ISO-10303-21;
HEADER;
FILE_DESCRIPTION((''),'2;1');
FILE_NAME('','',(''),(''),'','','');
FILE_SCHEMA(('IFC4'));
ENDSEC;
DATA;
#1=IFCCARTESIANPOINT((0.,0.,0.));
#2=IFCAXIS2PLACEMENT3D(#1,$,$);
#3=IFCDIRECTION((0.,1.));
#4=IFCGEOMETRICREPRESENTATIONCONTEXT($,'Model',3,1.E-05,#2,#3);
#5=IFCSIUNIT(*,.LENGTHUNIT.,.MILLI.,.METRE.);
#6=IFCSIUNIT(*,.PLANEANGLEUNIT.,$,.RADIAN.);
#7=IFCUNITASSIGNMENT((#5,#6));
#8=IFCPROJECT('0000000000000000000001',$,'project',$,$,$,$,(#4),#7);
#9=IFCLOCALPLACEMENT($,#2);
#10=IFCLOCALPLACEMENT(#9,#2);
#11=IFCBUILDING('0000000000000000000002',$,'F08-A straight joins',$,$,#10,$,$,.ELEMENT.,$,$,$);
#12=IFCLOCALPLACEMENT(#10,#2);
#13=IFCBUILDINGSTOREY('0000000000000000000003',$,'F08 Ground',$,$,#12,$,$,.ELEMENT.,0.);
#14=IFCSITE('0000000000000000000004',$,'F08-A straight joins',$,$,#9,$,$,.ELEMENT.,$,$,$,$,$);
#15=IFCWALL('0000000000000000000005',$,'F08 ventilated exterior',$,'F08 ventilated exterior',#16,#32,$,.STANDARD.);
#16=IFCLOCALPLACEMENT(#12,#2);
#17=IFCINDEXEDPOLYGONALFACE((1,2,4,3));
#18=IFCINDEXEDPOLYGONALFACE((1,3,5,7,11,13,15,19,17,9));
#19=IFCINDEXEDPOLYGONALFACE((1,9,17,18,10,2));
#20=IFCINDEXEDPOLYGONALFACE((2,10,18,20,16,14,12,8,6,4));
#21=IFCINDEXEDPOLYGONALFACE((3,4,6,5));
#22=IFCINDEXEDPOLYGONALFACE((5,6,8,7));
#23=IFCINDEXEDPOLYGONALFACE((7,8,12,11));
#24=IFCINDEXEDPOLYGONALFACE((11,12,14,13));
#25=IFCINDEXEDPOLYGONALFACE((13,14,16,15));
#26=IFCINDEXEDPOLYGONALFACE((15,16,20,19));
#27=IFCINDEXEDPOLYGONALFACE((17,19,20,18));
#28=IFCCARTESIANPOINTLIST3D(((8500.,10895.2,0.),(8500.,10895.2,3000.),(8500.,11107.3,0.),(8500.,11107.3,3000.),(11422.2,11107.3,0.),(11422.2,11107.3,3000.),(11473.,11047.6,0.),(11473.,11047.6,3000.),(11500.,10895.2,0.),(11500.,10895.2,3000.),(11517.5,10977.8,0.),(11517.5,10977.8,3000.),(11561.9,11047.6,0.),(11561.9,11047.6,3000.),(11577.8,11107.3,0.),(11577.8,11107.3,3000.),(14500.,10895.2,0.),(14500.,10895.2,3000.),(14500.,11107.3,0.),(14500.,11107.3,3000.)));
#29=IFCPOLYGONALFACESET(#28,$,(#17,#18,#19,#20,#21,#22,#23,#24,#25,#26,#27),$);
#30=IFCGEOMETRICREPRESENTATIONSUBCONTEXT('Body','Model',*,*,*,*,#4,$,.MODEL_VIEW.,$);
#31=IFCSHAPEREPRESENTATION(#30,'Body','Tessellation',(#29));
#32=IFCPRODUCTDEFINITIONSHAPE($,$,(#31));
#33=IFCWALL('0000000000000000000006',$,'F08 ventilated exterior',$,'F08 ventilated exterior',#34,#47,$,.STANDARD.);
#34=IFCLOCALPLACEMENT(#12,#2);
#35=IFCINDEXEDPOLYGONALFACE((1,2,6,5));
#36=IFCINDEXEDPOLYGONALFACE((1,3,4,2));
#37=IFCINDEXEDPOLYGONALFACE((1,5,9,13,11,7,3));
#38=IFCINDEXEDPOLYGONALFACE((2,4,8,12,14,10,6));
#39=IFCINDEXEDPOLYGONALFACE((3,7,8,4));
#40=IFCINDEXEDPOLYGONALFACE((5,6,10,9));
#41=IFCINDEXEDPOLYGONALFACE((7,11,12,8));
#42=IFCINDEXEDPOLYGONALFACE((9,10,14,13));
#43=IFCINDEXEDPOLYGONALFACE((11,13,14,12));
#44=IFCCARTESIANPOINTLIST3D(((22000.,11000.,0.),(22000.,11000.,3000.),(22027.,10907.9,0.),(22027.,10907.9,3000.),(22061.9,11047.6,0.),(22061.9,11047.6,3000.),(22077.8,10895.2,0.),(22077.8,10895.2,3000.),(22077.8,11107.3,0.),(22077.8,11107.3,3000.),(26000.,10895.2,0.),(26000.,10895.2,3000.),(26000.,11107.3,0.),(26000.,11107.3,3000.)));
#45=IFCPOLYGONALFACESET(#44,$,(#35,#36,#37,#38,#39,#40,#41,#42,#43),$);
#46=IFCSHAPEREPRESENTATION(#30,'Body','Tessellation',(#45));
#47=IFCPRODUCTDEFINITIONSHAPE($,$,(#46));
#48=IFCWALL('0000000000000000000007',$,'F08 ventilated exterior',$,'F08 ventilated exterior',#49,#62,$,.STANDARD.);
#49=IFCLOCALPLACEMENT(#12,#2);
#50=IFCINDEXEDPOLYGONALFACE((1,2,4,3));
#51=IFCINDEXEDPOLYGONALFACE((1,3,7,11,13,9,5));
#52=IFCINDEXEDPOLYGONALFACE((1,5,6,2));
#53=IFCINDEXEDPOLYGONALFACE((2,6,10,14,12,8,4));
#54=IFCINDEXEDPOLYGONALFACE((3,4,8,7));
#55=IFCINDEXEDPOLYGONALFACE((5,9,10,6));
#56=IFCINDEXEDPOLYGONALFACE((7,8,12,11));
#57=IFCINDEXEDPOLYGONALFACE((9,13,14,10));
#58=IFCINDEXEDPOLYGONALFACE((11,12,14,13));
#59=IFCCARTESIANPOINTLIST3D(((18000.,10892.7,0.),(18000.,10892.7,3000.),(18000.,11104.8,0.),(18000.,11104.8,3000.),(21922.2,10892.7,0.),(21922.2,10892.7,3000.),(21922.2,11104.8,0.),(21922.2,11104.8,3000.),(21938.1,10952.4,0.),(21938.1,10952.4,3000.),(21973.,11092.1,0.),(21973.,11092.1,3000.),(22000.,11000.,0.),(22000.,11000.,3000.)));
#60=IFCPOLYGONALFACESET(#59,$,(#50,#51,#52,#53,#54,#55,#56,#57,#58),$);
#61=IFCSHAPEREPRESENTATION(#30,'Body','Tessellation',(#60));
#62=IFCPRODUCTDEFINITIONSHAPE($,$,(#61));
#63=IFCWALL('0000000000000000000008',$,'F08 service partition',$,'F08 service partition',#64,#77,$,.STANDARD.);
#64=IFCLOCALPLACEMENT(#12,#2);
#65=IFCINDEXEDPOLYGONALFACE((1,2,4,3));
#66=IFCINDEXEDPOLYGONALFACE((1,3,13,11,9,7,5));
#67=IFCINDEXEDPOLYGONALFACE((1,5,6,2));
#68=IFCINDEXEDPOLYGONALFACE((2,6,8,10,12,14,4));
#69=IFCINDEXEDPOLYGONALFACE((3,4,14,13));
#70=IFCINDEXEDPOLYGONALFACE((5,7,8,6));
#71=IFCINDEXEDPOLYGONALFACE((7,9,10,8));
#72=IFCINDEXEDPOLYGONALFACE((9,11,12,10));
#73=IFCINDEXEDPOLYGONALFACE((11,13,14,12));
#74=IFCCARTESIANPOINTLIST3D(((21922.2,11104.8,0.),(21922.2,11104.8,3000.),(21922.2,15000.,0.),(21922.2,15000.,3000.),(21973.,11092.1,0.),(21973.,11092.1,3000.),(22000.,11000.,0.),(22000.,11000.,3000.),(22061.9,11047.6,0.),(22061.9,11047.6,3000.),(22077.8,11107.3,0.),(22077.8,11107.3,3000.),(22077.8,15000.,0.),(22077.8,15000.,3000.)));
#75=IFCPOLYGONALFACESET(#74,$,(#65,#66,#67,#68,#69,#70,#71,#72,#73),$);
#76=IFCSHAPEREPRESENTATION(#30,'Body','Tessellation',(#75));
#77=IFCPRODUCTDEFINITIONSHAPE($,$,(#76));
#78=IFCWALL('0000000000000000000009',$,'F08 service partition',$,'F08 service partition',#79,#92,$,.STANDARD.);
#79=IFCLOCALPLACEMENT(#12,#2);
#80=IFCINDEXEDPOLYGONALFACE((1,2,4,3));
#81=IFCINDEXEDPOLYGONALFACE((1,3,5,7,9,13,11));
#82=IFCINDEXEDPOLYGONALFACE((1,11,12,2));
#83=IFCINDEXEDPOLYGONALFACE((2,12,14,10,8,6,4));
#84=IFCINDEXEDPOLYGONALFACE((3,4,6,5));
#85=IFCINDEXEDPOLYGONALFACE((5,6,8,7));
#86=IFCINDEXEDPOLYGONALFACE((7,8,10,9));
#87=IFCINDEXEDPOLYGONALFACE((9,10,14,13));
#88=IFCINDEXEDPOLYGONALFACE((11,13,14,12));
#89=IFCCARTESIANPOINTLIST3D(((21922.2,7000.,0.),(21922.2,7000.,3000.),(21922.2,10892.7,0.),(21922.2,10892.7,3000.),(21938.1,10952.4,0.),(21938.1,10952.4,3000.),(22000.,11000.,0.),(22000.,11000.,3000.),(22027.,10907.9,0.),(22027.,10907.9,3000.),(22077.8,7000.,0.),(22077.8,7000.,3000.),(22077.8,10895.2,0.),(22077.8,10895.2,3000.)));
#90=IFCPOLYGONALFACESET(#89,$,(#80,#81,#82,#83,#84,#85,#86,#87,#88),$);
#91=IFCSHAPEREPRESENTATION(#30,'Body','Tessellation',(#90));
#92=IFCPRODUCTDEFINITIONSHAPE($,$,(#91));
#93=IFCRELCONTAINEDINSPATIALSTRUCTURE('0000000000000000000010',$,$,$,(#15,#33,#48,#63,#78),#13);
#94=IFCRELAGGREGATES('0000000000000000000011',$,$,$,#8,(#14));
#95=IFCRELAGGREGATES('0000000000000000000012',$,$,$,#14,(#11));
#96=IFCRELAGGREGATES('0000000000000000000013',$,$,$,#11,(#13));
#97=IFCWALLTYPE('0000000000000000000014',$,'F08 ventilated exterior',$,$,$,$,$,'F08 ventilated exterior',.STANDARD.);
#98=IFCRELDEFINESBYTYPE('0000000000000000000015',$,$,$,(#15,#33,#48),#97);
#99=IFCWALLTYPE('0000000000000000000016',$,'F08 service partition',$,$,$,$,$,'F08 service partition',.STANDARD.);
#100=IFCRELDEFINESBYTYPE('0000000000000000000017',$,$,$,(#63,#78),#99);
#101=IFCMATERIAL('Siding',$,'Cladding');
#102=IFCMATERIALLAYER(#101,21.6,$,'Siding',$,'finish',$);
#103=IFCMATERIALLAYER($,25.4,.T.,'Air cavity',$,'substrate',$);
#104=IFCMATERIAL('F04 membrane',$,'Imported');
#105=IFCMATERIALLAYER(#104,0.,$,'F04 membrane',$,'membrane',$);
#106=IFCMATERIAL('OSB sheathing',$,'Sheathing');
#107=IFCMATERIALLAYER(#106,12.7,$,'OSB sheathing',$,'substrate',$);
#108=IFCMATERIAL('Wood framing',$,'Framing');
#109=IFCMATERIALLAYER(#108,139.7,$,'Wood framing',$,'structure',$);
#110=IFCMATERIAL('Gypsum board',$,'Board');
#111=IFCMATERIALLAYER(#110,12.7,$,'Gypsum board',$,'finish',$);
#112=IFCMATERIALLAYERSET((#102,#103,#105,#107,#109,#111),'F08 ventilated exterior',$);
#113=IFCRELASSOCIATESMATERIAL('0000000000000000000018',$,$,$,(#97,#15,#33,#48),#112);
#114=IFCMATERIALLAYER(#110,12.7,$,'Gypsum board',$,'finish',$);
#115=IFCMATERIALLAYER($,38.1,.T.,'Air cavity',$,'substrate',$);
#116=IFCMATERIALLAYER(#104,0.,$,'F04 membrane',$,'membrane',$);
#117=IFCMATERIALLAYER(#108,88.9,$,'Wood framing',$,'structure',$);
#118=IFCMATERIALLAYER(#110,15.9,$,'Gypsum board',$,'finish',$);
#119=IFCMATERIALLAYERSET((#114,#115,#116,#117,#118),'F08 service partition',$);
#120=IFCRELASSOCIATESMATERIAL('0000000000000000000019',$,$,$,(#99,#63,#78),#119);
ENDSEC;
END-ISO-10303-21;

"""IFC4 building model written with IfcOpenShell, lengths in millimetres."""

from ifc_helpers import new_model, si_unit, direction, frame, origin, place, context, subcontext, project, spatial, polyline, outline, extrude, material, layer, layer_set, layer_usage, type_object, element, save


model = new_model("IFC4")

# Units and contexts
model_context = context("Model", 3, precision=1e-05, world=origin(), true_north=direction((0.0, 1.0)))
body_context = subcontext(model_context, "Body", "Model", "MODEL_VIEW")
ifc_project = project(units=[si_unit("LENGTHUNIT", "METRE", prefix="MILLI"), si_unit("PLANEANGLEUNIT", "RADIAN")], contexts=[model_context])

# Site, building, storey
site_placement = place(None, origin())
site = spatial("IfcSite", under=ifc_project, at=site_placement, Name="F08-A straight joins", CompositionType="ELEMENT")
building_placement = place(site_placement, origin())
building = spatial("IfcBuilding", under=site, at=building_placement, Name="F08-A straight joins", CompositionType="ELEMENT")
storey_placement = place(building_placement, origin())
storey = spatial("IfcBuildingStorey", under=building, at=storey_placement, Name="F08 Ground", CompositionType="ELEMENT", Elevation=0.0)

# Walls
ifc_material_1 = material(Name="Siding", Category="Cladding")
ifc_layer_1 = layer(ifc_material_1, 21.6, Name="Siding", Category="finish")
ifc_layer_2 = layer(None, 25.4, ventilated=True, Name="Air cavity", Category="substrate")
ifc_material_2 = material(Name="F04 membrane", Category="Imported")
ifc_layer_3 = layer(ifc_material_2, 0.0, Name="F04 membrane", Category="membrane")
ifc_material_3 = material(Name="OSB sheathing", Category="Sheathing")
ifc_layer_4 = layer(ifc_material_3, 12.7, Name="OSB sheathing", Category="substrate")
ifc_material_4 = material(Name="Wood framing", Category="Framing")
ifc_layer_5 = layer(ifc_material_4, 139.7, Name="Wood framing", Category="structure")
ifc_material_5 = material(Name="Gypsum board", Category="Board")
ifc_layer_6 = layer(ifc_material_5, 12.7, Name="Gypsum board", Category="finish")
ifc_layer_set_1 = layer_set([ifc_layer_1, ifc_layer_2, ifc_layer_3, ifc_layer_4, ifc_layer_5, ifc_layer_6], Name="F08 ventilated exterior")
wall_type_1 = type_object("IfcWallType", Name="F08 ventilated exterior", ElementType="F08 ventilated exterior", PredefinedType="STANDARD", material=ifc_layer_set_1)
ifc_layer_usage_1 = layer_usage(ifc_layer_set_1, "AXIS2", "NEGATIVE", 106.0)
wall_1_placement = place(storey_placement, frame((8500.0, 11001.3, 0.0), z_axis=(0.0, 0.0, 1.0), x_axis=(1.0, 0.0, 0.0)))
element("IfcWall", 1, at=wall_1_placement, inside=storey, type_object=wall_type_1, material=ifc_layer_usage_1, Name="F08 ventilated exterior", ObjectType="F08 ventilated exterior", PredefinedType="STANDARD", context=body_context, shape_type="SweptSolid", body=[
    extrude(outline(polyline([(0.0, -106.0), (3000.0, -106.0), (6000.0, -106.0), (6000.0, 106.0), (3077.8, 106.0), (3061.9, 46.4), (3017.5, -23.5), (2973.0, 46.4), (2922.2, 106.0), (0.0, 106.0), (0.0, -106.0)])), origin(), (0.0, 0.0, 1.0), 3000.0),
])
ifc_layer_usage_2 = layer_usage(ifc_layer_set_1, "AXIS2", "NEGATIVE", 106.0)
wall_2_placement = place(storey_placement, frame((22000.0, 11001.3, 0.0), z_axis=(0.0, 0.0, 1.0), x_axis=(1.0, 0.0, 0.0)))
element("IfcWall", 2, at=wall_2_placement, inside=storey, type_object=wall_type_1, material=ifc_layer_usage_2, Name="F08 ventilated exterior", ObjectType="F08 ventilated exterior", PredefinedType="STANDARD", context=body_context, shape_type="SweptSolid", body=[
    extrude(outline(polyline([(77.8, -106.0), (4000.0, -106.0), (4000.0, 106.0), (77.8, 106.0), (61.9, 46.4), (0.0, -1.3), (27.0, -93.3), (77.8, -106.0)])), origin(), (0.0, 0.0, 1.0), 3000.0),
])
ifc_layer_usage_3 = layer_usage(ifc_layer_set_1, "AXIS2", "NEGATIVE", 106.0)
wall_3_placement = place(storey_placement, frame((22000.0, 10998.7, 0.0), z_axis=(0.0, 0.0, 1.0), x_axis=(-1.0, 0.0, 0.0)))
element("IfcWall", 3, at=wall_3_placement, inside=storey, type_object=wall_type_1, material=ifc_layer_usage_3, Name="F08 ventilated exterior", ObjectType="F08 ventilated exterior", PredefinedType="STANDARD", context=body_context, shape_type="SweptSolid", body=[
    extrude(outline(polyline([(77.8, -106.0), (4000.0, -106.0), (4000.0, 106.0), (77.8, 106.0), (61.9, 46.4), (0.0, -1.3), (27.0, -93.3), (77.8, -106.0)])), origin(), (0.0, 0.0, 1.0), 3000.0),
])

# Walls
ifc_layer_7 = layer(ifc_material_5, 12.7, Name="Gypsum board", Category="finish")
ifc_layer_8 = layer(None, 38.1, ventilated=True, Name="Air cavity", Category="substrate")
ifc_layer_9 = layer(ifc_material_2, 0.0, Name="F04 membrane", Category="membrane")
ifc_layer_10 = layer(ifc_material_4, 88.9, Name="Wood framing", Category="structure")
ifc_layer_11 = layer(ifc_material_5, 15.9, Name="Gypsum board", Category="finish")
ifc_layer_set_2 = layer_set([ifc_layer_7, ifc_layer_8, ifc_layer_9, ifc_layer_10, ifc_layer_11], Name="F08 service partition")
wall_type_2 = type_object("IfcWallType", Name="F08 service partition", ElementType="F08 service partition", PredefinedType="STANDARD", material=ifc_layer_set_2)
ifc_layer_usage_4 = layer_usage(ifc_layer_set_2, "AXIS2", "NEGATIVE", 77.8)
wall_4_placement = place(storey_placement, frame((22000.0, 11000.0, 0.0), z_axis=(0.0, 0.0, 1.0), x_axis=(0.0, 1.0, 0.0)))
element("IfcWall", 4, at=wall_4_placement, inside=storey, type_object=wall_type_2, material=ifc_layer_usage_4, Name="F08 service partition", ObjectType="F08 service partition", PredefinedType="STANDARD", context=body_context, shape_type="SweptSolid", body=[
    extrude(outline(polyline([(107.3, -77.8), (4000.0, -77.8), (4000.0, 77.8), (104.8, 77.8), (92.1, 27.0), (0.0, 0.0), (47.6, -61.9), (107.3, -77.8)])), origin(), (0.0, 0.0, 1.0), 3000.0),
])
ifc_layer_usage_5 = layer_usage(ifc_layer_set_2, "AXIS2", "NEGATIVE", 77.8)
wall_5_placement = place(storey_placement, frame((22000.0, 11000.0, 0.0), z_axis=(0.0, 0.0, 1.0), x_axis=(0.0, -1.0, 0.0)))
element("IfcWall", 5, at=wall_5_placement, inside=storey, type_object=wall_type_2, material=ifc_layer_usage_5, Name="F08 service partition", ObjectType="F08 service partition", PredefinedType="STANDARD", context=body_context, shape_type="SweptSolid", body=[
    extrude(outline(polyline([(107.3, -77.8), (4000.0, -77.8), (4000.0, 77.8), (104.8, 77.8), (92.1, 27.0), (0.0, 0.0), (47.6, -61.9), (107.3, -77.8)])), origin(), (0.0, 0.0, 1.0), 3000.0),
])

save(model, "model.ifc")
